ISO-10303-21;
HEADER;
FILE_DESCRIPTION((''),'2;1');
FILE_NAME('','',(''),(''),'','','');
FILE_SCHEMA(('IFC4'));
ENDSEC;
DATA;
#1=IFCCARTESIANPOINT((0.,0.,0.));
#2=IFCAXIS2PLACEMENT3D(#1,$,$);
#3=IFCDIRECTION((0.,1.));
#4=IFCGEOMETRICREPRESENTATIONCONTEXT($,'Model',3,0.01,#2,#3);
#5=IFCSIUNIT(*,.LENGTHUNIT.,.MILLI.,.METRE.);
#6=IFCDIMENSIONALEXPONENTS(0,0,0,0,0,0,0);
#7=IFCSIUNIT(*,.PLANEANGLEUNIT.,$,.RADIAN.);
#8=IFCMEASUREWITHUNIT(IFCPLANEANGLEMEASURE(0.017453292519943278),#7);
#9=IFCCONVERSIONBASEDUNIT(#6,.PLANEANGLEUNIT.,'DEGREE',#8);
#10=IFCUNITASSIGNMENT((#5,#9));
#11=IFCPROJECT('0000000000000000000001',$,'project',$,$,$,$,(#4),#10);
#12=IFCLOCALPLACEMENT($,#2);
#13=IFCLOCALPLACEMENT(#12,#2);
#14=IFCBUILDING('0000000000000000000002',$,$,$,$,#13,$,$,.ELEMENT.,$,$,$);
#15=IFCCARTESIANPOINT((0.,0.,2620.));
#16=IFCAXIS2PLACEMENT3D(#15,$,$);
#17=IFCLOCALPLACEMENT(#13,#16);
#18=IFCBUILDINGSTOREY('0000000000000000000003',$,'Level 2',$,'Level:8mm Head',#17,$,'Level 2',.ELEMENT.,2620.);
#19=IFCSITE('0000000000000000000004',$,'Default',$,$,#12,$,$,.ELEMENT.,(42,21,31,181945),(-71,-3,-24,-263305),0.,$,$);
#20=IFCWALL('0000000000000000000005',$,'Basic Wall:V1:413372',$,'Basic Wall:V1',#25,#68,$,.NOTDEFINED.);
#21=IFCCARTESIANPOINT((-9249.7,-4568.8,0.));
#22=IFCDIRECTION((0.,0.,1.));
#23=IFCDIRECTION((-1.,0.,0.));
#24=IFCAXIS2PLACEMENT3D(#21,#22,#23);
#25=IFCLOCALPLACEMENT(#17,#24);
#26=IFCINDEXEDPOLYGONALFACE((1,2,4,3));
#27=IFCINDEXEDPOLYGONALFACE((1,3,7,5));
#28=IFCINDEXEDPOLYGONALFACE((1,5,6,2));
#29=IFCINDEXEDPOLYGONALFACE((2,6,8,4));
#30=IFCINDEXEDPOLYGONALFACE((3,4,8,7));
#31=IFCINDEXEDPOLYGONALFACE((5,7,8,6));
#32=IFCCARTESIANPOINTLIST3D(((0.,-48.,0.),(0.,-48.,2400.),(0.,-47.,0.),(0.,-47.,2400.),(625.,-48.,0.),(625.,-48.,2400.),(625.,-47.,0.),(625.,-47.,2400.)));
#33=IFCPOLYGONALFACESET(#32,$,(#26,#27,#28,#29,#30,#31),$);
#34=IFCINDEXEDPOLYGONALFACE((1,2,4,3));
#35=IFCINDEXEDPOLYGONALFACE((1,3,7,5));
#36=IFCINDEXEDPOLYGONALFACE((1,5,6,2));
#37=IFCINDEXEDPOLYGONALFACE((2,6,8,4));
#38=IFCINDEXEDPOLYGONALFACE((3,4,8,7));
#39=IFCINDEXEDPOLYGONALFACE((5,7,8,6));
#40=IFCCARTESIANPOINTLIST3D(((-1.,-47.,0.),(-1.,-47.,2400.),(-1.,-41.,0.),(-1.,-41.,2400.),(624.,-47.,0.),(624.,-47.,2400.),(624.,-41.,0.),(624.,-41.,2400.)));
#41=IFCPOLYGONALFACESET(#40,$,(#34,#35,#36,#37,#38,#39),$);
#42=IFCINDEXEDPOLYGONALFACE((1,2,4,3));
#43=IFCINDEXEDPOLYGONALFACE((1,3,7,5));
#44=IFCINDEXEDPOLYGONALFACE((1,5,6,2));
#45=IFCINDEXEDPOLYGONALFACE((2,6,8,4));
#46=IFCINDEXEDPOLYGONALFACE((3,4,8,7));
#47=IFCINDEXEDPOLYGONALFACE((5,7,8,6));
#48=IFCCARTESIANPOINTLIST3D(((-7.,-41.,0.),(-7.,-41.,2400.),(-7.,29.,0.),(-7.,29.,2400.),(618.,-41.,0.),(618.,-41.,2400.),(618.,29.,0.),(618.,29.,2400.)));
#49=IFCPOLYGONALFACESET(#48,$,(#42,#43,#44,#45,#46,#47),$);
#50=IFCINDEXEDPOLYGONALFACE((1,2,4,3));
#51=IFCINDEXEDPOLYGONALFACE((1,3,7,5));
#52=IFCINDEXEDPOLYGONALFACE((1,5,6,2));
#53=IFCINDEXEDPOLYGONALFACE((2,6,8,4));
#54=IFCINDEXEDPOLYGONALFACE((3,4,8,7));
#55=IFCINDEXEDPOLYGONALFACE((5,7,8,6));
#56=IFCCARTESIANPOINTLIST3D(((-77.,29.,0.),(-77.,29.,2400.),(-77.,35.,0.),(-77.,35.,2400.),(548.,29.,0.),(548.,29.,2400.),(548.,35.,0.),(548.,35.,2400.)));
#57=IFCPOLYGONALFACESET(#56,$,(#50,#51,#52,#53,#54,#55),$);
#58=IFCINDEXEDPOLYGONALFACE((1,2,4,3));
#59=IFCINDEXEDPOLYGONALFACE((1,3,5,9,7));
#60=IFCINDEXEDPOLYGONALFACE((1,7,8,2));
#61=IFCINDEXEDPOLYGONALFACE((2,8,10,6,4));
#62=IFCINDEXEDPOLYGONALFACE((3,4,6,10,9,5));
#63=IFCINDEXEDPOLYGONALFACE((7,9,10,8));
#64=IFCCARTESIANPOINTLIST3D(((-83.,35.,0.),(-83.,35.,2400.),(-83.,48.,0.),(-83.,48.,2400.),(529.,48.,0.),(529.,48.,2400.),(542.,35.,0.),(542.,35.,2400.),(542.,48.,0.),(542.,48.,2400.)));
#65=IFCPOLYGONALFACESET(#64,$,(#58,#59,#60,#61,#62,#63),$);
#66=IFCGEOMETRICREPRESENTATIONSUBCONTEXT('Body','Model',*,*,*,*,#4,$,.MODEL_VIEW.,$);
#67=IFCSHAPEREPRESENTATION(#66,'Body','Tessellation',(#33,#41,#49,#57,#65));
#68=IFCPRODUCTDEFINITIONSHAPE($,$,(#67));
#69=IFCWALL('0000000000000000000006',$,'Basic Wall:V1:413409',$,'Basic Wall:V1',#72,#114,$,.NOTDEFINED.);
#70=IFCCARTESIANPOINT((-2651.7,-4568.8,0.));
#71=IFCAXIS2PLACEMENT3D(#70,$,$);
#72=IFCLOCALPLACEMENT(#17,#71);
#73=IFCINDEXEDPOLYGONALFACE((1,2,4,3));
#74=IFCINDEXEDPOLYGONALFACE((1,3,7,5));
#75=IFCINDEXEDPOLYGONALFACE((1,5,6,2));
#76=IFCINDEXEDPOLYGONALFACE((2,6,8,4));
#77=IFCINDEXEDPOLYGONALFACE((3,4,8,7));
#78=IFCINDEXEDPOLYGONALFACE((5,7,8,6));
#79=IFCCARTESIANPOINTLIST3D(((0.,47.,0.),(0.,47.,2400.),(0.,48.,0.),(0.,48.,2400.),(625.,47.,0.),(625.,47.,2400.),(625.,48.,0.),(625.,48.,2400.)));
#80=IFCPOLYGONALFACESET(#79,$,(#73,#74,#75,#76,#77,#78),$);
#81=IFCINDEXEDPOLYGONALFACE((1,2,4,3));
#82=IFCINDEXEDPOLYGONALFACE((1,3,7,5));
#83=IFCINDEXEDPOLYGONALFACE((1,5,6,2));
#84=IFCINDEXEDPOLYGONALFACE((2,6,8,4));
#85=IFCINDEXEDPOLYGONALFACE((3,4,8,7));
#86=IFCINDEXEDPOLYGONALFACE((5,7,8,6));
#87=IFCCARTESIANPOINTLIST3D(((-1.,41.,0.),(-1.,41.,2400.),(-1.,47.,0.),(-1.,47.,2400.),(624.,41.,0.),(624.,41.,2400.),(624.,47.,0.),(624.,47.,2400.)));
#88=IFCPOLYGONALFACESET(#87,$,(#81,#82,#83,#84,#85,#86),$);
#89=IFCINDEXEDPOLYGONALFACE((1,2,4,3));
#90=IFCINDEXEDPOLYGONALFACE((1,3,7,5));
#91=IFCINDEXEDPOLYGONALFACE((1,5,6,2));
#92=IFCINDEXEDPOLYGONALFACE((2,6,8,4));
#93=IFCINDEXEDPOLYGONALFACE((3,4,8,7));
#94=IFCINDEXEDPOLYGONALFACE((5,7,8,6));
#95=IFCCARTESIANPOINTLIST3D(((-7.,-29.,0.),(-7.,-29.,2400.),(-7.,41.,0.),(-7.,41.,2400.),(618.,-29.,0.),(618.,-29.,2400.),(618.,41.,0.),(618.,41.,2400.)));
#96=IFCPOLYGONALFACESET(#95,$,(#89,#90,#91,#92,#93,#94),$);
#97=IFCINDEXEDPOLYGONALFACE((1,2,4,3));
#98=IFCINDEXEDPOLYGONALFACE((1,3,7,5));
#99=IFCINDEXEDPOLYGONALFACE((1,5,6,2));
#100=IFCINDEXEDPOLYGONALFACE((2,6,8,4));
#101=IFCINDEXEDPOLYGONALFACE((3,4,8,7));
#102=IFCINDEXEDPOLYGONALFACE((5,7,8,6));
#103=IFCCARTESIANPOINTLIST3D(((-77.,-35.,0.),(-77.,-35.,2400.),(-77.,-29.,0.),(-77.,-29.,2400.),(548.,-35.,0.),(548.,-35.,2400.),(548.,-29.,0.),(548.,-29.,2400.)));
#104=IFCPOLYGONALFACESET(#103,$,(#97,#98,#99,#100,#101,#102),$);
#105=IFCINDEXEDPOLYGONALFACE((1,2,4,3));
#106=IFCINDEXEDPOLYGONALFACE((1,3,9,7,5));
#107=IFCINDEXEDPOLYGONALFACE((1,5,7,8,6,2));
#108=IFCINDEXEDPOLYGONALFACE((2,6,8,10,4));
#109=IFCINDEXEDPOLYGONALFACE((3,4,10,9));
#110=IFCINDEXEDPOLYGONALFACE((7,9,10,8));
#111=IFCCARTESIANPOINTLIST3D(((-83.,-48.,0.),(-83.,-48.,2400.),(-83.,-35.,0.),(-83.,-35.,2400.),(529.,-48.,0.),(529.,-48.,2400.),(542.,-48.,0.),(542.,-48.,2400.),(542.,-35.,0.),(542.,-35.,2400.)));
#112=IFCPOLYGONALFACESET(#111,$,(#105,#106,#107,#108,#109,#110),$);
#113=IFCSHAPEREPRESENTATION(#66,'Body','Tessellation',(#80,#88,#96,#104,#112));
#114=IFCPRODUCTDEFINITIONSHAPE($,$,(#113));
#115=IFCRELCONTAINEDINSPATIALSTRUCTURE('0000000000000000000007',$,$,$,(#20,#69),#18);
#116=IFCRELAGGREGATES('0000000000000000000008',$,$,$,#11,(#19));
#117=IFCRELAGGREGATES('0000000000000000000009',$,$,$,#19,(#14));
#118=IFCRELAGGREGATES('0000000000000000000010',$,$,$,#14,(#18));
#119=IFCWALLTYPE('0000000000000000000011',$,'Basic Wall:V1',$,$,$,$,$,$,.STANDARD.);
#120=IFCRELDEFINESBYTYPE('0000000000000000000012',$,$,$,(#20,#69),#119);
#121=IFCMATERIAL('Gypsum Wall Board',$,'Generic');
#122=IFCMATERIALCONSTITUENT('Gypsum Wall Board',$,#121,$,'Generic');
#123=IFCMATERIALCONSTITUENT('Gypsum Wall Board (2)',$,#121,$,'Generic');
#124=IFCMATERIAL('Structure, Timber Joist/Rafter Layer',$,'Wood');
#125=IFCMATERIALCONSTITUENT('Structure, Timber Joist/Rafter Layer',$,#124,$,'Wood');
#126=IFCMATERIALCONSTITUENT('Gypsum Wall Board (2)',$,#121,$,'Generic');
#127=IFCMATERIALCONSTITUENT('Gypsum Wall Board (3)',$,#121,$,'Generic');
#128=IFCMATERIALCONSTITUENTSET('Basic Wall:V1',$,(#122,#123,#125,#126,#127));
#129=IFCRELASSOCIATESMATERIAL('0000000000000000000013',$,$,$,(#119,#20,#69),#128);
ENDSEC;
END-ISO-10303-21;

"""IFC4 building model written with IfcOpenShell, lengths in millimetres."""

from ifc_helpers import new_model, entity, si_unit, converted_unit, direction, frame, origin, place, context, subcontext, project, spatial, indexed_curve, outline, extrude, material, constituent, constituent_set, type_object, element, save


model = new_model("IFC4")

# Units and contexts
model_context = context("Model", 3, precision=0.01, world=origin(), true_north=direction((0.0, 1.0)))
body_context = subcontext(model_context, "Body", "Model", "MODEL_VIEW")
ifc_project = project(units=[si_unit("LENGTHUNIT", "METRE", prefix="MILLI"), converted_unit("PLANEANGLEUNIT", "DEGREE", entity("IfcPlaneAngleMeasure", 0.017453292519943278), si_unit("PLANEANGLEUNIT", "RADIAN"), dimensions=[0, 0, 0, 0, 0, 0, 0])], contexts=[model_context])

# Site, building, storey
site_placement = place(None, origin())
site = spatial("IfcSite", under=ifc_project, at=site_placement, Name="Default", CompositionType="ELEMENT", RefLatitude=(42, 21, 31, 181945), RefLongitude=(-71, -3, -24, -263305), RefElevation=0.0)
building_placement = place(site_placement, origin())
building = spatial("IfcBuilding", under=site, at=building_placement, CompositionType="ELEMENT")
storey_placement = place(building_placement, frame((0.0, 0.0, 2620.0)))
storey = spatial("IfcBuildingStorey", under=building, at=storey_placement, Name="Level 2", ObjectType="Level:8mm Head", LongName="Level 2", CompositionType="ELEMENT", Elevation=2620.0)

# Walls
ifc_material_1 = material(Name="Gypsum Wall Board", Category="Generic")
ifc_constituent_1 = constituent(ifc_material_1, Name="Gypsum Wall Board", Category="Generic")
ifc_constituent_2 = constituent(ifc_material_1, Name="Gypsum Wall Board (2)", Category="Generic")
ifc_material_2 = material(Name="Structure, Timber Joist/Rafter Layer", Category="Wood")
ifc_constituent_3 = constituent(ifc_material_2, Name="Structure, Timber Joist/Rafter Layer", Category="Wood")
ifc_constituent_4 = constituent(ifc_material_1, Name="Gypsum Wall Board (2)", Category="Generic")
ifc_constituent_5 = constituent(ifc_material_1, Name="Gypsum Wall Board (3)", Category="Generic")
ifc_constituent_set_1 = constituent_set(constituents=[ifc_constituent_1, ifc_constituent_2, ifc_constituent_3, ifc_constituent_4, ifc_constituent_5], Name="Basic Wall:V1")
wall_type_1 = type_object("IfcWallType", Name="Basic Wall:V1", PredefinedType="STANDARD", material=ifc_constituent_set_1)
wall_1_placement = place(storey_placement, frame((-9249.7, -4568.8, 0.0), z_axis=(0.0, 0.0, 1.0), x_axis=(-1.0, 0.0, 0.0)))
element("IfcWall", 1, at=wall_1_placement, inside=storey, type_object=wall_type_1, material=ifc_constituent_set_1, Name="Basic Wall:V1:413372", ObjectType="Basic Wall:V1", PredefinedType="NOTDEFINED", context=body_context, shape_type="SweptSolid", body=[
    extrude(outline(indexed_curve([(-0.5, -312.5), (0.5, -312.5), (0.5, 312.5), (-0.5, 312.5), (-0.5, -312.5)], self_intersect=False)), frame((312.5, -47.5, 0.0), z_axis=(0.0, 0.0, 1.0), x_axis=(0.0, 1.0, 0.0)), (0.0, 0.0, 1.0), 2400.0),
    extrude(outline(indexed_curve([(-312.5, -3.0), (312.5, -3.0), (312.5, 3.0), (-312.5, 3.0), (-312.5, -3.0)], self_intersect=False)), frame((311.5, -44.0, 0.0)), (0.0, 0.0, 1.0), 2400.0),
    extrude(outline(indexed_curve([(-312.5, -35.0), (312.5, -35.0), (312.5, 35.0), (-312.5, 35.0), (-312.5, -35.0)], self_intersect=False)), frame((305.5, -6.0, 0.0)), (0.0, 0.0, 1.0), 2400.0),
    extrude(outline(indexed_curve([(-312.5, -3.0), (312.5, -3.0), (312.5, 3.0), (-312.5, 3.0), (-312.5, -3.0)], self_intersect=False)), frame((235.5, 32.0, 0.0)), (0.0, 0.0, 1.0), 2400.0),
    extrude(outline(indexed_curve([(-239.6, -5.2), (372.4, -5.2), (372.4, 7.8), (-252.6, 7.8), (-252.6, -5.2), (-239.6, -5.2)], self_intersect=False)), frame((289.4, 42.8, 0.0), z_axis=(0.0, 0.0, 1.0), x_axis=(-1.0, 0.0, 0.0)), (0.0, 0.0, 1.0), 2400.0),
])
wall_2_placement = place(storey_placement, frame((-2651.7, -4568.8, 0.0)))
element("IfcWall", 2, at=wall_2_placement, inside=storey, type_object=wall_type_1, material=ifc_constituent_set_1, Name="Basic Wall:V1:413409", ObjectType="Basic Wall:V1", PredefinedType="NOTDEFINED", context=body_context, shape_type="SweptSolid", body=[
    extrude(outline(indexed_curve([(-0.5, -312.5), (0.5, -312.5), (0.5, 312.5), (-0.5, 312.5), (-0.5, -312.5)], self_intersect=False)), frame((312.5, 47.5, 0.0), z_axis=(0.0, 0.0, 1.0), x_axis=(0.0, -1.0, 0.0)), (0.0, 0.0, 1.0), 2400.0),
    extrude(outline(indexed_curve([(-312.5, -3.0), (312.5, -3.0), (312.5, 3.0), (-312.5, 3.0), (-312.5, -3.0)], self_intersect=False)), frame((311.5, 44.0, 0.0)), (0.0, 0.0, 1.0), 2400.0),
    extrude(outline(indexed_curve([(-312.5, -35.0), (312.5, -35.0), (312.5, 35.0), (-312.5, 35.0), (-312.5, -35.0)], self_intersect=False)), frame((305.5, 6.0, 0.0)), (0.0, 0.0, 1.0), 2400.0),
    extrude(outline(indexed_curve([(-312.5, -3.0), (312.5, -3.0), (312.5, 3.0), (-312.5, 3.0), (-312.5, -3.0)], self_intersect=False)), frame((235.5, -32.0, 0.0)), (0.0, 0.0, 1.0), 2400.0),
    extrude(outline(indexed_curve([(239.6, -5.2), (252.6, -5.2), (252.6, 7.8), (-372.4, 7.8), (-372.4, -5.2), (239.6, -5.2)], self_intersect=False)), frame((289.4, -42.8, 0.0)), (0.0, 0.0, 1.0), 2400.0),
])

save(model, "model.ifc")
